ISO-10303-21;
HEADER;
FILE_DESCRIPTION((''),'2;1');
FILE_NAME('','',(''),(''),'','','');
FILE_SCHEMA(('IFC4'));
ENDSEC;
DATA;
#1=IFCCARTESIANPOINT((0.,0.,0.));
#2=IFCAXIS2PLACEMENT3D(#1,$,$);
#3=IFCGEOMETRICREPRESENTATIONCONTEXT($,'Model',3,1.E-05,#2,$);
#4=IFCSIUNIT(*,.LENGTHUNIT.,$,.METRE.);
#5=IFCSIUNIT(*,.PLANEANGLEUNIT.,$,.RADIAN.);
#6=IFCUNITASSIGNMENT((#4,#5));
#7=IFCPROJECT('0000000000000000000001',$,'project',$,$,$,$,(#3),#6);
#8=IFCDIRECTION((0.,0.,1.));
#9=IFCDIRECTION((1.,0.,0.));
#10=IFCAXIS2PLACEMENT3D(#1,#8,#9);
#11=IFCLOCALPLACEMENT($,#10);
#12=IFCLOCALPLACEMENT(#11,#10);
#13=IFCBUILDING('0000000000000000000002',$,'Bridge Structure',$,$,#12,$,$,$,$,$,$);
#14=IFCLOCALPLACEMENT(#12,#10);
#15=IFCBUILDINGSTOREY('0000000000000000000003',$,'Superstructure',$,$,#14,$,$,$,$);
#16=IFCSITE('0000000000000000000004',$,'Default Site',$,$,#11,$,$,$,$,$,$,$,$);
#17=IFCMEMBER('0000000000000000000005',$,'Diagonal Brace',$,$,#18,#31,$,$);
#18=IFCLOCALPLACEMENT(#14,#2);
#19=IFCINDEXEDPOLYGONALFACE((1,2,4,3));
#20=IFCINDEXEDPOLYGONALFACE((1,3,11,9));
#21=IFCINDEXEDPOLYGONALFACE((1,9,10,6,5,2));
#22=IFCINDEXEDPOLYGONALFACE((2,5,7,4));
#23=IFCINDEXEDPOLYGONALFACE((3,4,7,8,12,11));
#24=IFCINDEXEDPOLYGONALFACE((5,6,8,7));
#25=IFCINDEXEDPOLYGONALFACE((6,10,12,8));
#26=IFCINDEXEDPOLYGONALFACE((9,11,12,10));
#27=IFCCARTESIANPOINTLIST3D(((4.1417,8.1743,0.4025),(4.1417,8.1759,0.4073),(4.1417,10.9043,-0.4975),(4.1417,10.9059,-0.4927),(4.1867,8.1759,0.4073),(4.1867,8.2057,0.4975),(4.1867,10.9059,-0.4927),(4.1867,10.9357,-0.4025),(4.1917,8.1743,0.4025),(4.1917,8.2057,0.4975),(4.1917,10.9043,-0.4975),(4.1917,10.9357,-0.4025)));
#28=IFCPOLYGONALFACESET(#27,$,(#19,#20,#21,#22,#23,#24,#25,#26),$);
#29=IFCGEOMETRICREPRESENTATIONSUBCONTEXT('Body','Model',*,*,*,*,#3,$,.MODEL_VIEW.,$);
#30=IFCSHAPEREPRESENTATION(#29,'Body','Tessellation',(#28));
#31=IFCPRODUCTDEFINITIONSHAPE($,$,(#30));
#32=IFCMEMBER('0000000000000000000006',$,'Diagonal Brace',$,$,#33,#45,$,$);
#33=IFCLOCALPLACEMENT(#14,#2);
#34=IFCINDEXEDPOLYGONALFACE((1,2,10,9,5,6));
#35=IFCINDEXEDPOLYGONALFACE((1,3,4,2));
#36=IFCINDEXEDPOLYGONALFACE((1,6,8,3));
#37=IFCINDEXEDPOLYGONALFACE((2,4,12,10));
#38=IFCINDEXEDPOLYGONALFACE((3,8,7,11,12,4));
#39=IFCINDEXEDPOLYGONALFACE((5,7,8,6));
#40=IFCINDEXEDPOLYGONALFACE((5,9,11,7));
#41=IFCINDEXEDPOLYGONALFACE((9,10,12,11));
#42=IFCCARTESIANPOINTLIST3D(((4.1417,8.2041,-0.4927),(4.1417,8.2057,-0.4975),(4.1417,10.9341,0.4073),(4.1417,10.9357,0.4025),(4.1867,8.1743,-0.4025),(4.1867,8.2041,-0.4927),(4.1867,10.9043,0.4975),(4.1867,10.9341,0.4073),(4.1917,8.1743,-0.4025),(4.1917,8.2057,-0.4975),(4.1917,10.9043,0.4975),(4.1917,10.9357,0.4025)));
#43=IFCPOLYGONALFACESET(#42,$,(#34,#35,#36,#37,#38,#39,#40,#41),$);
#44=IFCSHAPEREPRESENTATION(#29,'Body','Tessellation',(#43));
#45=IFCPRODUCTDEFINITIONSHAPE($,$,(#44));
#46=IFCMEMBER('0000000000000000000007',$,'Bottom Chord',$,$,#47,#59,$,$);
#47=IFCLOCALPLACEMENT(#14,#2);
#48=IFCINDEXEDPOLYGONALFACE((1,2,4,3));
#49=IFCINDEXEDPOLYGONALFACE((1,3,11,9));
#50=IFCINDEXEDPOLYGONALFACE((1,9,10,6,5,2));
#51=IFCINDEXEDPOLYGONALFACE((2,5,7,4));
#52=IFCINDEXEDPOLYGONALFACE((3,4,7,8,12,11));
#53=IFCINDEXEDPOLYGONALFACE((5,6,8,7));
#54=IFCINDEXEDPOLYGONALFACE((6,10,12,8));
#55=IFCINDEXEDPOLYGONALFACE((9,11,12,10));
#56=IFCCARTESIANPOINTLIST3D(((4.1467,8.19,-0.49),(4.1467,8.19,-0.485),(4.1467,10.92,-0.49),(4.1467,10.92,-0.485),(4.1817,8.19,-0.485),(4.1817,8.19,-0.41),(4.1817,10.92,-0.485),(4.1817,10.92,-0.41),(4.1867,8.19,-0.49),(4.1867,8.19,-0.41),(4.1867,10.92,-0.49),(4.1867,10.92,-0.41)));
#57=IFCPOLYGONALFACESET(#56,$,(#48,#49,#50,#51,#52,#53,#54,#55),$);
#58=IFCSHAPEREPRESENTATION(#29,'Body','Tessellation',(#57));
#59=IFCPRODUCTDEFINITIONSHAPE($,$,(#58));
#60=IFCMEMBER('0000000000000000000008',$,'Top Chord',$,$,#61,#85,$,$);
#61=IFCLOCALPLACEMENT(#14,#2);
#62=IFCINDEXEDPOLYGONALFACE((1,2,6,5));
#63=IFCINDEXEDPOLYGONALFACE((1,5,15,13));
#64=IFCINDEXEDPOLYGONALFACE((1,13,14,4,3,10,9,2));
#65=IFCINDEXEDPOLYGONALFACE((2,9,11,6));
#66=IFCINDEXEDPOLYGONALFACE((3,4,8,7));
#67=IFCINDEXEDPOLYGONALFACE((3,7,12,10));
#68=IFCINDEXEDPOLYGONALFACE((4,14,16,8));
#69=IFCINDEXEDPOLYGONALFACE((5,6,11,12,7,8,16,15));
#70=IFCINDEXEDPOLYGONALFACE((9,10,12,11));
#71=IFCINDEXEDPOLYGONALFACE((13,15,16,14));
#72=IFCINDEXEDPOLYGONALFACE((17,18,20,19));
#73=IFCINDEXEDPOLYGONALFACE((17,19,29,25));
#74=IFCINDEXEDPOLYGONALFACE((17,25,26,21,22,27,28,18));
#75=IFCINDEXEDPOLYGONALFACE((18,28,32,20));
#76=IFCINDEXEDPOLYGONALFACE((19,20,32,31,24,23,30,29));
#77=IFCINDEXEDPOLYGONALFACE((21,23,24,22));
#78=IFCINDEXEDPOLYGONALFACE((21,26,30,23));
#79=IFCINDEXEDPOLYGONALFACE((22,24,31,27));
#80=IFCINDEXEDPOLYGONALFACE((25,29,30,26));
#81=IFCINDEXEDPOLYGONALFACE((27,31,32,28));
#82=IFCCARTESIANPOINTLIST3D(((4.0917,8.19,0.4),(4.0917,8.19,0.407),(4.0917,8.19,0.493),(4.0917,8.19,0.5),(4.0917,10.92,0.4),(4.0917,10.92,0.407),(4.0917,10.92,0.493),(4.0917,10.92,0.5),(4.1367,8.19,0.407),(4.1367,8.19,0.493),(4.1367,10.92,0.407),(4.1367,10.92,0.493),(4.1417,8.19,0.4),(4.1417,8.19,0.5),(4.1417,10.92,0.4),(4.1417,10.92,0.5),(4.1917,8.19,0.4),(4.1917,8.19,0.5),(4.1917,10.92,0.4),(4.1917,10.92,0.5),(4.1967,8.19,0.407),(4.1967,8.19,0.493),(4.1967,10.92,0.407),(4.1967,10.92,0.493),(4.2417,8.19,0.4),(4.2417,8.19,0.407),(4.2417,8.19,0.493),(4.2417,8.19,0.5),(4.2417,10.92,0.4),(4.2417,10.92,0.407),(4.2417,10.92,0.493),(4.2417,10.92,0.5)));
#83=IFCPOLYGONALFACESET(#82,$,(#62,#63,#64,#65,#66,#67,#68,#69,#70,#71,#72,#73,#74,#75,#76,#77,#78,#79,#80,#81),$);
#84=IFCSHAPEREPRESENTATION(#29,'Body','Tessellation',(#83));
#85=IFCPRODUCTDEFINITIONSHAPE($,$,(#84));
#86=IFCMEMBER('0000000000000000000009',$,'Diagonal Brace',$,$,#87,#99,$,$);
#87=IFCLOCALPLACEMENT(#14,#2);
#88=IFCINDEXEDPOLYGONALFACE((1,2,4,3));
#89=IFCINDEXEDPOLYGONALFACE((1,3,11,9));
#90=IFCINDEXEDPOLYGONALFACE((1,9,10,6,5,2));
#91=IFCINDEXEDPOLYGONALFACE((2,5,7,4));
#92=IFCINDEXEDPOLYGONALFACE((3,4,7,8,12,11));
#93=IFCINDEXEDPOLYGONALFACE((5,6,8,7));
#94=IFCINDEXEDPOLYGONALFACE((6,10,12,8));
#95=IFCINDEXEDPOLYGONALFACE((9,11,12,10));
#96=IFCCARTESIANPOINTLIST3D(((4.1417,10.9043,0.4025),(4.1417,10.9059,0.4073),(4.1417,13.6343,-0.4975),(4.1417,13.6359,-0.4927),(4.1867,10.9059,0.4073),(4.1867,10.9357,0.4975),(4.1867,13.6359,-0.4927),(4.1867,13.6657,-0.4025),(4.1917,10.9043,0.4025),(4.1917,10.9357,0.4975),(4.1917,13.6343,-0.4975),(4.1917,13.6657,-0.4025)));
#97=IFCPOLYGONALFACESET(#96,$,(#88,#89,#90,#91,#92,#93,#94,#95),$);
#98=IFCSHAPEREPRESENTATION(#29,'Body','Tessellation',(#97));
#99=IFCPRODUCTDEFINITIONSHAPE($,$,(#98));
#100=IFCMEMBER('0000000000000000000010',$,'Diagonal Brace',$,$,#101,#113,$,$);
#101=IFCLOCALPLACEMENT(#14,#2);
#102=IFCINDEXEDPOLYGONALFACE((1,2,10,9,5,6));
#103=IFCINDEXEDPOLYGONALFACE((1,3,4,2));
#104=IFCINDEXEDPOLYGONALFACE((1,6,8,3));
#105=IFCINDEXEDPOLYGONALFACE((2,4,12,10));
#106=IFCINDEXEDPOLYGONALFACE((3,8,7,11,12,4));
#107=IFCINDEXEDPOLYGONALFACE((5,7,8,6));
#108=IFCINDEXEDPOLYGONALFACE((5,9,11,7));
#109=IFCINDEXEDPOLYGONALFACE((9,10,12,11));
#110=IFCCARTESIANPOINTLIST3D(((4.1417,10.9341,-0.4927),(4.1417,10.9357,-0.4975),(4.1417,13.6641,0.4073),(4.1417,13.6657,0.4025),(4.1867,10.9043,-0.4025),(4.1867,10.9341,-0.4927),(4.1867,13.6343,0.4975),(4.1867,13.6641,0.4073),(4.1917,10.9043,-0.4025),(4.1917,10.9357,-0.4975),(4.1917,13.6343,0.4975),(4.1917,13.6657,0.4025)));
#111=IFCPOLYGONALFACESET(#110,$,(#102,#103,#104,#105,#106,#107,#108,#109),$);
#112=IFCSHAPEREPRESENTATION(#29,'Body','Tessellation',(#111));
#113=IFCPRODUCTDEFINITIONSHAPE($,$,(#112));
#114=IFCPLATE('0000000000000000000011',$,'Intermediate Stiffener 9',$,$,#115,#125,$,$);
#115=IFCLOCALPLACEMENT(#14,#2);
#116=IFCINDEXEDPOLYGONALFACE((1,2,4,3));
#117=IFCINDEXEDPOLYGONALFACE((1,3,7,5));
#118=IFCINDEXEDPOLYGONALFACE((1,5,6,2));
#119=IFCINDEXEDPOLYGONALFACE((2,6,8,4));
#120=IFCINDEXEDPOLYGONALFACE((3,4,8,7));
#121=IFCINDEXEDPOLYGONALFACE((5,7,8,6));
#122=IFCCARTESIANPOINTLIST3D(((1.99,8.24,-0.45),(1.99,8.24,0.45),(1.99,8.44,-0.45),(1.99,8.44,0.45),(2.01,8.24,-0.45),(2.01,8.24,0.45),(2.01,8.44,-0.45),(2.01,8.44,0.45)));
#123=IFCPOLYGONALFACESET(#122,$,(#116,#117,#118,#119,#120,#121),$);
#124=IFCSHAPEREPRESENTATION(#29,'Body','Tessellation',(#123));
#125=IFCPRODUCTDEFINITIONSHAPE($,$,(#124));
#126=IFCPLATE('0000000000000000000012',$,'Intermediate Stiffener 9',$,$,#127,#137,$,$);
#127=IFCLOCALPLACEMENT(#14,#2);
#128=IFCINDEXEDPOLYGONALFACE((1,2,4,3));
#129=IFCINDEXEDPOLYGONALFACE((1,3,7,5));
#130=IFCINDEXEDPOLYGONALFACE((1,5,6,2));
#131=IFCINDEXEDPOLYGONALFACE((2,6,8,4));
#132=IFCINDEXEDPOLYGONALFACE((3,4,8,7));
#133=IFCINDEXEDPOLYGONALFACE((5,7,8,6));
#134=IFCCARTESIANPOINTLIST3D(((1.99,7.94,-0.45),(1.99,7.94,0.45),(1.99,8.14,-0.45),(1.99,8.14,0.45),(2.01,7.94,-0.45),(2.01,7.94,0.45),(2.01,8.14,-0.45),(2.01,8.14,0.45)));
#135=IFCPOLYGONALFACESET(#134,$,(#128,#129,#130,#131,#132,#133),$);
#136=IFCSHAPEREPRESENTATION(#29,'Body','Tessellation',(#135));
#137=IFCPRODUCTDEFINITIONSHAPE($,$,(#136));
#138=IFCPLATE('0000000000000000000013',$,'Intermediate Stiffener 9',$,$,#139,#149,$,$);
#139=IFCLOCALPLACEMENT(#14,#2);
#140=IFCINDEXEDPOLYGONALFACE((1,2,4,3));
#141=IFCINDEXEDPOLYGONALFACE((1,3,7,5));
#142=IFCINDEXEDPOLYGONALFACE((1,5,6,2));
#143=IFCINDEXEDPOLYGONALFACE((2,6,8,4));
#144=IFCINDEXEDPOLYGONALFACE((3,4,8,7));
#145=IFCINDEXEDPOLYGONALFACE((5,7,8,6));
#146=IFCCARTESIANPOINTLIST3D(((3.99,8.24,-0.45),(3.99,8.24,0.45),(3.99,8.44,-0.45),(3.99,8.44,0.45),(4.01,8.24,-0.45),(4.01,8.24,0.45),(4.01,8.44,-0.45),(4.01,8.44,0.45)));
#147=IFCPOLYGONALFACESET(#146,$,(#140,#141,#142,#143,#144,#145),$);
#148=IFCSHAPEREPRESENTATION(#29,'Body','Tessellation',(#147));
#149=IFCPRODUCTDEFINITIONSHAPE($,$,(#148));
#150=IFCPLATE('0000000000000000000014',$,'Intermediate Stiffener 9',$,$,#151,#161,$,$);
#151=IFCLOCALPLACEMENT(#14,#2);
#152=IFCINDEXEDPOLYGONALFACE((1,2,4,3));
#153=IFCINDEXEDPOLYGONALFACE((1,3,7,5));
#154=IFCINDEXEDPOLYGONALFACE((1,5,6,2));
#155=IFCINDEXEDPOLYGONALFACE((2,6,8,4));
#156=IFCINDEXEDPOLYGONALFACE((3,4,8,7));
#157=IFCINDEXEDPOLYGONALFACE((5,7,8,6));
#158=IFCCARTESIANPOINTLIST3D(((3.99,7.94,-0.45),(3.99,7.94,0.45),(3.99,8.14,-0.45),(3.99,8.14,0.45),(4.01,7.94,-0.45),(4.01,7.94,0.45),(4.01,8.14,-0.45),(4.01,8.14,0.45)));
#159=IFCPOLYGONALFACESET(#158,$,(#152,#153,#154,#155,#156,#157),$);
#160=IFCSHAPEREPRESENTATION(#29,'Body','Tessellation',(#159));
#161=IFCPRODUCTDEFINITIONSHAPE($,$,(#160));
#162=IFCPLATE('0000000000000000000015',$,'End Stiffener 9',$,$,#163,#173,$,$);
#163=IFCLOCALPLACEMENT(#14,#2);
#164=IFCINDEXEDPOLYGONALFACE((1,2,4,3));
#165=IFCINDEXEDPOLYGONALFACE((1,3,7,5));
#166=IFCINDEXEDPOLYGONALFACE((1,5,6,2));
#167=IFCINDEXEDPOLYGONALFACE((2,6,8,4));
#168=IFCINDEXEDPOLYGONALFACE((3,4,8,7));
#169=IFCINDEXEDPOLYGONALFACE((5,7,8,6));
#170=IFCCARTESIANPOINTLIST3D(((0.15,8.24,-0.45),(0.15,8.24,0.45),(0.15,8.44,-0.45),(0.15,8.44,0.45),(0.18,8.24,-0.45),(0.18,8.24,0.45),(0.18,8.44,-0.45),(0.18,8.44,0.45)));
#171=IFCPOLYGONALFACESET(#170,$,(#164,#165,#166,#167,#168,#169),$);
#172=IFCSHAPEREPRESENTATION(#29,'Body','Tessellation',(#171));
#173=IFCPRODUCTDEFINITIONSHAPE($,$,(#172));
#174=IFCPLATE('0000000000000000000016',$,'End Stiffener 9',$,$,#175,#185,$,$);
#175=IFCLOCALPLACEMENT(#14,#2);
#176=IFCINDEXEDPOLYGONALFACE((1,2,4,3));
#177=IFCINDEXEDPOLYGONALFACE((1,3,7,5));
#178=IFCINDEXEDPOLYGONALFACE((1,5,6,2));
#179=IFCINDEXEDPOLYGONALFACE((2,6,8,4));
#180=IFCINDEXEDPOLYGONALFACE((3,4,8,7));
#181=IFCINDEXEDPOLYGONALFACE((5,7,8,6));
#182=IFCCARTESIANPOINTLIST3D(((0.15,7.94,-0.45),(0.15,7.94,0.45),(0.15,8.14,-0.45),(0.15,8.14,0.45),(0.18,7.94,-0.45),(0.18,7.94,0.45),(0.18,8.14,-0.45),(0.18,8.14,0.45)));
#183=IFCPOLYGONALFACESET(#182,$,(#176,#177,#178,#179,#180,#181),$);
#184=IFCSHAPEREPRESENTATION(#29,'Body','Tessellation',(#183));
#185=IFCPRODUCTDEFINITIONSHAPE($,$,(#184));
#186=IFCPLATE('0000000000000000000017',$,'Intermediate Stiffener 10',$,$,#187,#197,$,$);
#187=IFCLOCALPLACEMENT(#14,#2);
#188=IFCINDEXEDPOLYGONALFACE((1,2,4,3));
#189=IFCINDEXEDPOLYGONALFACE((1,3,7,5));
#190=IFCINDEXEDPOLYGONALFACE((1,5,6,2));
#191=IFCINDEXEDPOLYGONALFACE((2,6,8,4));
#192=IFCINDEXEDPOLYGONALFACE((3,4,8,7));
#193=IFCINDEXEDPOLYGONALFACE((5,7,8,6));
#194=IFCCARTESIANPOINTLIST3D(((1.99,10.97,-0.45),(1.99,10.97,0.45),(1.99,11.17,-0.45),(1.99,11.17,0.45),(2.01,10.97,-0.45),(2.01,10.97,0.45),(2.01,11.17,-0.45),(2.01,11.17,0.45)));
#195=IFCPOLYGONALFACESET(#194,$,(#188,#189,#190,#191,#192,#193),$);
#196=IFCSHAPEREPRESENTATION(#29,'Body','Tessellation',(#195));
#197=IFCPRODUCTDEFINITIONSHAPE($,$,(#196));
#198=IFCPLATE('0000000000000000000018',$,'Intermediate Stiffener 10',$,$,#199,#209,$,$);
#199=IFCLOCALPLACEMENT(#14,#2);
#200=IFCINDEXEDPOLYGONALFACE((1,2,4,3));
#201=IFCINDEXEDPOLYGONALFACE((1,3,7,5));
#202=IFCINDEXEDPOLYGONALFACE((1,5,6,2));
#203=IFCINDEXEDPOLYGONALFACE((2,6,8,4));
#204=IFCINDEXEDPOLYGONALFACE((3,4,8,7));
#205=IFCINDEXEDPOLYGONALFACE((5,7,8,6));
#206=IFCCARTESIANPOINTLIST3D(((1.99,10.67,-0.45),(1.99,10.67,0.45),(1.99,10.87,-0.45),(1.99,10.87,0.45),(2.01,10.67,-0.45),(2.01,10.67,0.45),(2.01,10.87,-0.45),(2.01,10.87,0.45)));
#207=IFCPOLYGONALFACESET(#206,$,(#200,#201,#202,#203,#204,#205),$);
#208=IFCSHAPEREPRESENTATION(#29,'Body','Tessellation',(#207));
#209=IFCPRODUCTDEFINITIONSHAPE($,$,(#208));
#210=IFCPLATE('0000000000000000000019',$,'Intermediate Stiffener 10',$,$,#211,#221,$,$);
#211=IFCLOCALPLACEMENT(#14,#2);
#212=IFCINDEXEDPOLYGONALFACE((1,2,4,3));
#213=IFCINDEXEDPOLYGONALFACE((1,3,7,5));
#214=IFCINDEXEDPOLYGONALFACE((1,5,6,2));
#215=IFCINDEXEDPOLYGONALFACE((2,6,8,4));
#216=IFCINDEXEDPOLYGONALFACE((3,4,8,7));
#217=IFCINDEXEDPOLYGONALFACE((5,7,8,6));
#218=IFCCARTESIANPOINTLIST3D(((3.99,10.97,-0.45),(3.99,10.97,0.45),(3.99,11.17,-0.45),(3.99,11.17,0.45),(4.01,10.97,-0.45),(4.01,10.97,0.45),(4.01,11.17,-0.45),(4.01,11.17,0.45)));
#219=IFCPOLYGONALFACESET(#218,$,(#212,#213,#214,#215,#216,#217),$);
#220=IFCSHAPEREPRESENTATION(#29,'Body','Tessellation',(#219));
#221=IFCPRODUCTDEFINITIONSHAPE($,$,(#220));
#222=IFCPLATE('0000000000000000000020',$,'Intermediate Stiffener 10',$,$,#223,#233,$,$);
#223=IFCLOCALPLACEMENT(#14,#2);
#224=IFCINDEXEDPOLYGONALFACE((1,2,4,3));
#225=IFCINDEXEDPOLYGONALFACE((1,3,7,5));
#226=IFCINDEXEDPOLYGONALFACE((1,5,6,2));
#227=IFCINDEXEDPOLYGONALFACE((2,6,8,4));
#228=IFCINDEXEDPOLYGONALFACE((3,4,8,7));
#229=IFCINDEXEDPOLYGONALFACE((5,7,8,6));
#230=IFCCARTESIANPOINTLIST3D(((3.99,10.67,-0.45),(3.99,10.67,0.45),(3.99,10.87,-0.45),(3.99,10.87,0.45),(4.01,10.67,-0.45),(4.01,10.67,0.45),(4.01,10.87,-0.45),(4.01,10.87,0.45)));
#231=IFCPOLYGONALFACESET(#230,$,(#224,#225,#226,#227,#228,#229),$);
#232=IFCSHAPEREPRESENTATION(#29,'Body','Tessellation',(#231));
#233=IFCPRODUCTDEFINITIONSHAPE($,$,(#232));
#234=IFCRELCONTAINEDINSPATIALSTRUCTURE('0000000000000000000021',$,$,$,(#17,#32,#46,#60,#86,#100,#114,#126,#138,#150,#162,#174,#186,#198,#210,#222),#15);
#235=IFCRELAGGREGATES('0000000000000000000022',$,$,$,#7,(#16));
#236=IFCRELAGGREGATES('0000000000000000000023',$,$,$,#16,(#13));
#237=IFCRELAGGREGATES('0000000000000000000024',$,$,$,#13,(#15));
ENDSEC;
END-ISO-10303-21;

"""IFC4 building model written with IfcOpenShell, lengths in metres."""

from ifc_helpers import new_model, si_unit, frame, origin, origin_with_axes, origin_2d_with_axis, place, context, subcontext, project, spatial, polyline, rectangle, l_section, outline, composite_profile, extrude, element, save


model = new_model("IFC4")

# Units and contexts
model_context = context("Model", 3, precision=1e-05, world=origin())
body_context = subcontext(model_context, "Body", "Model", "MODEL_VIEW")
ifc_project = project(units=[si_unit("LENGTHUNIT", "METRE"), si_unit("PLANEANGLEUNIT", "RADIAN")], contexts=[model_context])

# Site, building, storey
site_placement = place(None, origin_with_axes())
site = spatial("IfcSite", under=ifc_project, at=site_placement, Name="Default Site")
building_placement = place(site_placement, origin_with_axes())
building = spatial("IfcBuilding", under=site, at=building_placement, Name="Bridge Structure")
storey_placement = place(building_placement, origin_with_axes())
storey = spatial("IfcBuildingStorey", under=building, at=storey_placement, Name="Superstructure")

# Members
for number, where, z_axis, x_axis, name in (
    (1, (4.1667, 8.19, 0.45), (0.0, 0.949722, -0.313095), (-1.0, 0.0, 0.0), "Diagonal Brace"),
    (2, (4.1667, 8.19, -0.45), (0.0, 0.949722, 0.313095), (-1.0, 0.0, 0.0), "Diagonal Brace"),
):
    element("IfcMember", number, at=place(storey_placement, frame(where, z_axis=z_axis, x_axis=x_axis)), inside=storey, Name=name, context=body_context, shape_type="SweptSolid", body=[
        extrude(l_section(Depth=0.1, Width=0.05, Thickness=0.005, at=origin_2d_with_axis()), origin_with_axes(), (0.0, 0.0, 1.0), 2.8745),
    ])
member_1_placement = place(storey_placement, frame((4.1667, 8.19, -0.45), z_axis=(0.0, 1.0, 0.0), x_axis=(-1.0, 0.0, 0.0)))
element("IfcMember", 3, at=member_1_placement, inside=storey, Name="Bottom Chord", context=body_context, shape_type="SweptSolid", body=[
    extrude(l_section(Depth=0.08, Width=0.04, Thickness=0.005, at=origin_2d_with_axis()), origin_with_axes(), (0.0, 0.0, 1.0), 2.73),
])
member_2_placement = place(storey_placement, frame((4.1667, 8.19, 0.45), z_axis=(0.0, 1.0, 0.0), x_axis=(-1.0, 0.0, 0.0)))
element("IfcMember", 4, at=member_2_placement, inside=storey, Name="Top Chord", context=body_context, shape_type="SweptSolid", body=[
    extrude(composite_profile([outline(polyline([(-0.025, -0.05), (-0.025, 0.05), (-0.075, 0.05), (-0.075, 0.043), (-0.03, 0.043), (-0.03, -0.043), (-0.075, -0.043), (-0.075, -0.05), (-0.025, -0.05)])), outline(polyline([(0.025, -0.05), (0.075, -0.05), (0.075, -0.043), (0.03, -0.043), (0.03, 0.043), (0.075, 0.043), (0.075, 0.05), (0.025, 0.05), (0.025, -0.05)]))]), origin_with_axes(), (0.0, 0.0, 1.0), 2.73),
])
for number, where, z_axis, x_axis, name in (
    (5, (4.1667, 10.92, 0.45), (0.0, 0.949722, -0.313095), (-1.0, 0.0, 0.0), "Diagonal Brace"),
    (6, (4.1667, 10.92, -0.45), (0.0, 0.949722, 0.313095), (-1.0, 0.0, 0.0), "Diagonal Brace"),
):
    element("IfcMember", number, at=place(storey_placement, frame(where, z_axis=z_axis, x_axis=x_axis)), inside=storey, Name=name, context=body_context, shape_type="SweptSolid", body=[
        extrude(l_section(Depth=0.1, Width=0.05, Thickness=0.005, at=origin_2d_with_axis()), origin_with_axes(), (0.0, 0.0, 1.0), 2.8745),
    ])

# Plates
for number, where, z_axis, x_axis, name in (
    (7, (2.0, 8.34, -0.45), (0.0, 0.0, 1.0), (1.0, 0.0, 0.0), "Intermediate Stiffener 9"),
    (8, (2.0, 8.04, -0.45), (0.0, 0.0, 1.0), (1.0, 0.0, 0.0), "Intermediate Stiffener 9"),
    (9, (4.0, 8.34, -0.45), (0.0, 0.0, 1.0), (1.0, 0.0, 0.0), "Intermediate Stiffener 9"),
    (10, (4.0, 8.04, -0.45), (0.0, 0.0, 1.0), (1.0, 0.0, 0.0), "Intermediate Stiffener 9"),
):
    element("IfcPlate", number, at=place(storey_placement, frame(where, z_axis=z_axis, x_axis=x_axis)), inside=storey, Name=name, context=body_context, shape_type="SweptSolid", body=[
        extrude(rectangle(XDim=0.02, YDim=0.2, at=origin_2d_with_axis()), origin_with_axes(), (0.0, 0.0, 1.0), 0.9),
    ])
for number, where, z_axis, x_axis, name in (
    (11, (0.165, 8.34, -0.45), (0.0, 0.0, 1.0), (1.0, 0.0, 0.0), "End Stiffener 9"),
    (12, (0.165, 8.04, -0.45), (0.0, 0.0, 1.0), (1.0, 0.0, 0.0), "End Stiffener 9"),
):
    element("IfcPlate", number, at=place(storey_placement, frame(where, z_axis=z_axis, x_axis=x_axis)), inside=storey, Name=name, context=body_context, shape_type="SweptSolid", body=[
        extrude(rectangle(XDim=0.03, YDim=0.2, at=origin_2d_with_axis()), origin_with_axes(), (0.0, 0.0, 1.0), 0.9),
    ])
for number, where, z_axis, x_axis, name in (
    (13, (2.0, 11.07, -0.45), (0.0, 0.0, 1.0), (1.0, 0.0, 0.0), "Intermediate Stiffener 10"),
    (14, (2.0, 10.77, -0.45), (0.0, 0.0, 1.0), (1.0, 0.0, 0.0), "Intermediate Stiffener 10"),
    (15, (4.0, 11.07, -0.45), (0.0, 0.0, 1.0), (1.0, 0.0, 0.0), "Intermediate Stiffener 10"),
    (16, (4.0, 10.77, -0.45), (0.0, 0.0, 1.0), (1.0, 0.0, 0.0), "Intermediate Stiffener 10"),
):
    element("IfcPlate", number, at=place(storey_placement, frame(where, z_axis=z_axis, x_axis=x_axis)), inside=storey, Name=name, context=body_context, shape_type="SweptSolid", body=[
        extrude(rectangle(XDim=0.02, YDim=0.2, at=origin_2d_with_axis()), origin_with_axes(), (0.0, 0.0, 1.0), 0.9),
    ])

save(model, "model.ifc")
